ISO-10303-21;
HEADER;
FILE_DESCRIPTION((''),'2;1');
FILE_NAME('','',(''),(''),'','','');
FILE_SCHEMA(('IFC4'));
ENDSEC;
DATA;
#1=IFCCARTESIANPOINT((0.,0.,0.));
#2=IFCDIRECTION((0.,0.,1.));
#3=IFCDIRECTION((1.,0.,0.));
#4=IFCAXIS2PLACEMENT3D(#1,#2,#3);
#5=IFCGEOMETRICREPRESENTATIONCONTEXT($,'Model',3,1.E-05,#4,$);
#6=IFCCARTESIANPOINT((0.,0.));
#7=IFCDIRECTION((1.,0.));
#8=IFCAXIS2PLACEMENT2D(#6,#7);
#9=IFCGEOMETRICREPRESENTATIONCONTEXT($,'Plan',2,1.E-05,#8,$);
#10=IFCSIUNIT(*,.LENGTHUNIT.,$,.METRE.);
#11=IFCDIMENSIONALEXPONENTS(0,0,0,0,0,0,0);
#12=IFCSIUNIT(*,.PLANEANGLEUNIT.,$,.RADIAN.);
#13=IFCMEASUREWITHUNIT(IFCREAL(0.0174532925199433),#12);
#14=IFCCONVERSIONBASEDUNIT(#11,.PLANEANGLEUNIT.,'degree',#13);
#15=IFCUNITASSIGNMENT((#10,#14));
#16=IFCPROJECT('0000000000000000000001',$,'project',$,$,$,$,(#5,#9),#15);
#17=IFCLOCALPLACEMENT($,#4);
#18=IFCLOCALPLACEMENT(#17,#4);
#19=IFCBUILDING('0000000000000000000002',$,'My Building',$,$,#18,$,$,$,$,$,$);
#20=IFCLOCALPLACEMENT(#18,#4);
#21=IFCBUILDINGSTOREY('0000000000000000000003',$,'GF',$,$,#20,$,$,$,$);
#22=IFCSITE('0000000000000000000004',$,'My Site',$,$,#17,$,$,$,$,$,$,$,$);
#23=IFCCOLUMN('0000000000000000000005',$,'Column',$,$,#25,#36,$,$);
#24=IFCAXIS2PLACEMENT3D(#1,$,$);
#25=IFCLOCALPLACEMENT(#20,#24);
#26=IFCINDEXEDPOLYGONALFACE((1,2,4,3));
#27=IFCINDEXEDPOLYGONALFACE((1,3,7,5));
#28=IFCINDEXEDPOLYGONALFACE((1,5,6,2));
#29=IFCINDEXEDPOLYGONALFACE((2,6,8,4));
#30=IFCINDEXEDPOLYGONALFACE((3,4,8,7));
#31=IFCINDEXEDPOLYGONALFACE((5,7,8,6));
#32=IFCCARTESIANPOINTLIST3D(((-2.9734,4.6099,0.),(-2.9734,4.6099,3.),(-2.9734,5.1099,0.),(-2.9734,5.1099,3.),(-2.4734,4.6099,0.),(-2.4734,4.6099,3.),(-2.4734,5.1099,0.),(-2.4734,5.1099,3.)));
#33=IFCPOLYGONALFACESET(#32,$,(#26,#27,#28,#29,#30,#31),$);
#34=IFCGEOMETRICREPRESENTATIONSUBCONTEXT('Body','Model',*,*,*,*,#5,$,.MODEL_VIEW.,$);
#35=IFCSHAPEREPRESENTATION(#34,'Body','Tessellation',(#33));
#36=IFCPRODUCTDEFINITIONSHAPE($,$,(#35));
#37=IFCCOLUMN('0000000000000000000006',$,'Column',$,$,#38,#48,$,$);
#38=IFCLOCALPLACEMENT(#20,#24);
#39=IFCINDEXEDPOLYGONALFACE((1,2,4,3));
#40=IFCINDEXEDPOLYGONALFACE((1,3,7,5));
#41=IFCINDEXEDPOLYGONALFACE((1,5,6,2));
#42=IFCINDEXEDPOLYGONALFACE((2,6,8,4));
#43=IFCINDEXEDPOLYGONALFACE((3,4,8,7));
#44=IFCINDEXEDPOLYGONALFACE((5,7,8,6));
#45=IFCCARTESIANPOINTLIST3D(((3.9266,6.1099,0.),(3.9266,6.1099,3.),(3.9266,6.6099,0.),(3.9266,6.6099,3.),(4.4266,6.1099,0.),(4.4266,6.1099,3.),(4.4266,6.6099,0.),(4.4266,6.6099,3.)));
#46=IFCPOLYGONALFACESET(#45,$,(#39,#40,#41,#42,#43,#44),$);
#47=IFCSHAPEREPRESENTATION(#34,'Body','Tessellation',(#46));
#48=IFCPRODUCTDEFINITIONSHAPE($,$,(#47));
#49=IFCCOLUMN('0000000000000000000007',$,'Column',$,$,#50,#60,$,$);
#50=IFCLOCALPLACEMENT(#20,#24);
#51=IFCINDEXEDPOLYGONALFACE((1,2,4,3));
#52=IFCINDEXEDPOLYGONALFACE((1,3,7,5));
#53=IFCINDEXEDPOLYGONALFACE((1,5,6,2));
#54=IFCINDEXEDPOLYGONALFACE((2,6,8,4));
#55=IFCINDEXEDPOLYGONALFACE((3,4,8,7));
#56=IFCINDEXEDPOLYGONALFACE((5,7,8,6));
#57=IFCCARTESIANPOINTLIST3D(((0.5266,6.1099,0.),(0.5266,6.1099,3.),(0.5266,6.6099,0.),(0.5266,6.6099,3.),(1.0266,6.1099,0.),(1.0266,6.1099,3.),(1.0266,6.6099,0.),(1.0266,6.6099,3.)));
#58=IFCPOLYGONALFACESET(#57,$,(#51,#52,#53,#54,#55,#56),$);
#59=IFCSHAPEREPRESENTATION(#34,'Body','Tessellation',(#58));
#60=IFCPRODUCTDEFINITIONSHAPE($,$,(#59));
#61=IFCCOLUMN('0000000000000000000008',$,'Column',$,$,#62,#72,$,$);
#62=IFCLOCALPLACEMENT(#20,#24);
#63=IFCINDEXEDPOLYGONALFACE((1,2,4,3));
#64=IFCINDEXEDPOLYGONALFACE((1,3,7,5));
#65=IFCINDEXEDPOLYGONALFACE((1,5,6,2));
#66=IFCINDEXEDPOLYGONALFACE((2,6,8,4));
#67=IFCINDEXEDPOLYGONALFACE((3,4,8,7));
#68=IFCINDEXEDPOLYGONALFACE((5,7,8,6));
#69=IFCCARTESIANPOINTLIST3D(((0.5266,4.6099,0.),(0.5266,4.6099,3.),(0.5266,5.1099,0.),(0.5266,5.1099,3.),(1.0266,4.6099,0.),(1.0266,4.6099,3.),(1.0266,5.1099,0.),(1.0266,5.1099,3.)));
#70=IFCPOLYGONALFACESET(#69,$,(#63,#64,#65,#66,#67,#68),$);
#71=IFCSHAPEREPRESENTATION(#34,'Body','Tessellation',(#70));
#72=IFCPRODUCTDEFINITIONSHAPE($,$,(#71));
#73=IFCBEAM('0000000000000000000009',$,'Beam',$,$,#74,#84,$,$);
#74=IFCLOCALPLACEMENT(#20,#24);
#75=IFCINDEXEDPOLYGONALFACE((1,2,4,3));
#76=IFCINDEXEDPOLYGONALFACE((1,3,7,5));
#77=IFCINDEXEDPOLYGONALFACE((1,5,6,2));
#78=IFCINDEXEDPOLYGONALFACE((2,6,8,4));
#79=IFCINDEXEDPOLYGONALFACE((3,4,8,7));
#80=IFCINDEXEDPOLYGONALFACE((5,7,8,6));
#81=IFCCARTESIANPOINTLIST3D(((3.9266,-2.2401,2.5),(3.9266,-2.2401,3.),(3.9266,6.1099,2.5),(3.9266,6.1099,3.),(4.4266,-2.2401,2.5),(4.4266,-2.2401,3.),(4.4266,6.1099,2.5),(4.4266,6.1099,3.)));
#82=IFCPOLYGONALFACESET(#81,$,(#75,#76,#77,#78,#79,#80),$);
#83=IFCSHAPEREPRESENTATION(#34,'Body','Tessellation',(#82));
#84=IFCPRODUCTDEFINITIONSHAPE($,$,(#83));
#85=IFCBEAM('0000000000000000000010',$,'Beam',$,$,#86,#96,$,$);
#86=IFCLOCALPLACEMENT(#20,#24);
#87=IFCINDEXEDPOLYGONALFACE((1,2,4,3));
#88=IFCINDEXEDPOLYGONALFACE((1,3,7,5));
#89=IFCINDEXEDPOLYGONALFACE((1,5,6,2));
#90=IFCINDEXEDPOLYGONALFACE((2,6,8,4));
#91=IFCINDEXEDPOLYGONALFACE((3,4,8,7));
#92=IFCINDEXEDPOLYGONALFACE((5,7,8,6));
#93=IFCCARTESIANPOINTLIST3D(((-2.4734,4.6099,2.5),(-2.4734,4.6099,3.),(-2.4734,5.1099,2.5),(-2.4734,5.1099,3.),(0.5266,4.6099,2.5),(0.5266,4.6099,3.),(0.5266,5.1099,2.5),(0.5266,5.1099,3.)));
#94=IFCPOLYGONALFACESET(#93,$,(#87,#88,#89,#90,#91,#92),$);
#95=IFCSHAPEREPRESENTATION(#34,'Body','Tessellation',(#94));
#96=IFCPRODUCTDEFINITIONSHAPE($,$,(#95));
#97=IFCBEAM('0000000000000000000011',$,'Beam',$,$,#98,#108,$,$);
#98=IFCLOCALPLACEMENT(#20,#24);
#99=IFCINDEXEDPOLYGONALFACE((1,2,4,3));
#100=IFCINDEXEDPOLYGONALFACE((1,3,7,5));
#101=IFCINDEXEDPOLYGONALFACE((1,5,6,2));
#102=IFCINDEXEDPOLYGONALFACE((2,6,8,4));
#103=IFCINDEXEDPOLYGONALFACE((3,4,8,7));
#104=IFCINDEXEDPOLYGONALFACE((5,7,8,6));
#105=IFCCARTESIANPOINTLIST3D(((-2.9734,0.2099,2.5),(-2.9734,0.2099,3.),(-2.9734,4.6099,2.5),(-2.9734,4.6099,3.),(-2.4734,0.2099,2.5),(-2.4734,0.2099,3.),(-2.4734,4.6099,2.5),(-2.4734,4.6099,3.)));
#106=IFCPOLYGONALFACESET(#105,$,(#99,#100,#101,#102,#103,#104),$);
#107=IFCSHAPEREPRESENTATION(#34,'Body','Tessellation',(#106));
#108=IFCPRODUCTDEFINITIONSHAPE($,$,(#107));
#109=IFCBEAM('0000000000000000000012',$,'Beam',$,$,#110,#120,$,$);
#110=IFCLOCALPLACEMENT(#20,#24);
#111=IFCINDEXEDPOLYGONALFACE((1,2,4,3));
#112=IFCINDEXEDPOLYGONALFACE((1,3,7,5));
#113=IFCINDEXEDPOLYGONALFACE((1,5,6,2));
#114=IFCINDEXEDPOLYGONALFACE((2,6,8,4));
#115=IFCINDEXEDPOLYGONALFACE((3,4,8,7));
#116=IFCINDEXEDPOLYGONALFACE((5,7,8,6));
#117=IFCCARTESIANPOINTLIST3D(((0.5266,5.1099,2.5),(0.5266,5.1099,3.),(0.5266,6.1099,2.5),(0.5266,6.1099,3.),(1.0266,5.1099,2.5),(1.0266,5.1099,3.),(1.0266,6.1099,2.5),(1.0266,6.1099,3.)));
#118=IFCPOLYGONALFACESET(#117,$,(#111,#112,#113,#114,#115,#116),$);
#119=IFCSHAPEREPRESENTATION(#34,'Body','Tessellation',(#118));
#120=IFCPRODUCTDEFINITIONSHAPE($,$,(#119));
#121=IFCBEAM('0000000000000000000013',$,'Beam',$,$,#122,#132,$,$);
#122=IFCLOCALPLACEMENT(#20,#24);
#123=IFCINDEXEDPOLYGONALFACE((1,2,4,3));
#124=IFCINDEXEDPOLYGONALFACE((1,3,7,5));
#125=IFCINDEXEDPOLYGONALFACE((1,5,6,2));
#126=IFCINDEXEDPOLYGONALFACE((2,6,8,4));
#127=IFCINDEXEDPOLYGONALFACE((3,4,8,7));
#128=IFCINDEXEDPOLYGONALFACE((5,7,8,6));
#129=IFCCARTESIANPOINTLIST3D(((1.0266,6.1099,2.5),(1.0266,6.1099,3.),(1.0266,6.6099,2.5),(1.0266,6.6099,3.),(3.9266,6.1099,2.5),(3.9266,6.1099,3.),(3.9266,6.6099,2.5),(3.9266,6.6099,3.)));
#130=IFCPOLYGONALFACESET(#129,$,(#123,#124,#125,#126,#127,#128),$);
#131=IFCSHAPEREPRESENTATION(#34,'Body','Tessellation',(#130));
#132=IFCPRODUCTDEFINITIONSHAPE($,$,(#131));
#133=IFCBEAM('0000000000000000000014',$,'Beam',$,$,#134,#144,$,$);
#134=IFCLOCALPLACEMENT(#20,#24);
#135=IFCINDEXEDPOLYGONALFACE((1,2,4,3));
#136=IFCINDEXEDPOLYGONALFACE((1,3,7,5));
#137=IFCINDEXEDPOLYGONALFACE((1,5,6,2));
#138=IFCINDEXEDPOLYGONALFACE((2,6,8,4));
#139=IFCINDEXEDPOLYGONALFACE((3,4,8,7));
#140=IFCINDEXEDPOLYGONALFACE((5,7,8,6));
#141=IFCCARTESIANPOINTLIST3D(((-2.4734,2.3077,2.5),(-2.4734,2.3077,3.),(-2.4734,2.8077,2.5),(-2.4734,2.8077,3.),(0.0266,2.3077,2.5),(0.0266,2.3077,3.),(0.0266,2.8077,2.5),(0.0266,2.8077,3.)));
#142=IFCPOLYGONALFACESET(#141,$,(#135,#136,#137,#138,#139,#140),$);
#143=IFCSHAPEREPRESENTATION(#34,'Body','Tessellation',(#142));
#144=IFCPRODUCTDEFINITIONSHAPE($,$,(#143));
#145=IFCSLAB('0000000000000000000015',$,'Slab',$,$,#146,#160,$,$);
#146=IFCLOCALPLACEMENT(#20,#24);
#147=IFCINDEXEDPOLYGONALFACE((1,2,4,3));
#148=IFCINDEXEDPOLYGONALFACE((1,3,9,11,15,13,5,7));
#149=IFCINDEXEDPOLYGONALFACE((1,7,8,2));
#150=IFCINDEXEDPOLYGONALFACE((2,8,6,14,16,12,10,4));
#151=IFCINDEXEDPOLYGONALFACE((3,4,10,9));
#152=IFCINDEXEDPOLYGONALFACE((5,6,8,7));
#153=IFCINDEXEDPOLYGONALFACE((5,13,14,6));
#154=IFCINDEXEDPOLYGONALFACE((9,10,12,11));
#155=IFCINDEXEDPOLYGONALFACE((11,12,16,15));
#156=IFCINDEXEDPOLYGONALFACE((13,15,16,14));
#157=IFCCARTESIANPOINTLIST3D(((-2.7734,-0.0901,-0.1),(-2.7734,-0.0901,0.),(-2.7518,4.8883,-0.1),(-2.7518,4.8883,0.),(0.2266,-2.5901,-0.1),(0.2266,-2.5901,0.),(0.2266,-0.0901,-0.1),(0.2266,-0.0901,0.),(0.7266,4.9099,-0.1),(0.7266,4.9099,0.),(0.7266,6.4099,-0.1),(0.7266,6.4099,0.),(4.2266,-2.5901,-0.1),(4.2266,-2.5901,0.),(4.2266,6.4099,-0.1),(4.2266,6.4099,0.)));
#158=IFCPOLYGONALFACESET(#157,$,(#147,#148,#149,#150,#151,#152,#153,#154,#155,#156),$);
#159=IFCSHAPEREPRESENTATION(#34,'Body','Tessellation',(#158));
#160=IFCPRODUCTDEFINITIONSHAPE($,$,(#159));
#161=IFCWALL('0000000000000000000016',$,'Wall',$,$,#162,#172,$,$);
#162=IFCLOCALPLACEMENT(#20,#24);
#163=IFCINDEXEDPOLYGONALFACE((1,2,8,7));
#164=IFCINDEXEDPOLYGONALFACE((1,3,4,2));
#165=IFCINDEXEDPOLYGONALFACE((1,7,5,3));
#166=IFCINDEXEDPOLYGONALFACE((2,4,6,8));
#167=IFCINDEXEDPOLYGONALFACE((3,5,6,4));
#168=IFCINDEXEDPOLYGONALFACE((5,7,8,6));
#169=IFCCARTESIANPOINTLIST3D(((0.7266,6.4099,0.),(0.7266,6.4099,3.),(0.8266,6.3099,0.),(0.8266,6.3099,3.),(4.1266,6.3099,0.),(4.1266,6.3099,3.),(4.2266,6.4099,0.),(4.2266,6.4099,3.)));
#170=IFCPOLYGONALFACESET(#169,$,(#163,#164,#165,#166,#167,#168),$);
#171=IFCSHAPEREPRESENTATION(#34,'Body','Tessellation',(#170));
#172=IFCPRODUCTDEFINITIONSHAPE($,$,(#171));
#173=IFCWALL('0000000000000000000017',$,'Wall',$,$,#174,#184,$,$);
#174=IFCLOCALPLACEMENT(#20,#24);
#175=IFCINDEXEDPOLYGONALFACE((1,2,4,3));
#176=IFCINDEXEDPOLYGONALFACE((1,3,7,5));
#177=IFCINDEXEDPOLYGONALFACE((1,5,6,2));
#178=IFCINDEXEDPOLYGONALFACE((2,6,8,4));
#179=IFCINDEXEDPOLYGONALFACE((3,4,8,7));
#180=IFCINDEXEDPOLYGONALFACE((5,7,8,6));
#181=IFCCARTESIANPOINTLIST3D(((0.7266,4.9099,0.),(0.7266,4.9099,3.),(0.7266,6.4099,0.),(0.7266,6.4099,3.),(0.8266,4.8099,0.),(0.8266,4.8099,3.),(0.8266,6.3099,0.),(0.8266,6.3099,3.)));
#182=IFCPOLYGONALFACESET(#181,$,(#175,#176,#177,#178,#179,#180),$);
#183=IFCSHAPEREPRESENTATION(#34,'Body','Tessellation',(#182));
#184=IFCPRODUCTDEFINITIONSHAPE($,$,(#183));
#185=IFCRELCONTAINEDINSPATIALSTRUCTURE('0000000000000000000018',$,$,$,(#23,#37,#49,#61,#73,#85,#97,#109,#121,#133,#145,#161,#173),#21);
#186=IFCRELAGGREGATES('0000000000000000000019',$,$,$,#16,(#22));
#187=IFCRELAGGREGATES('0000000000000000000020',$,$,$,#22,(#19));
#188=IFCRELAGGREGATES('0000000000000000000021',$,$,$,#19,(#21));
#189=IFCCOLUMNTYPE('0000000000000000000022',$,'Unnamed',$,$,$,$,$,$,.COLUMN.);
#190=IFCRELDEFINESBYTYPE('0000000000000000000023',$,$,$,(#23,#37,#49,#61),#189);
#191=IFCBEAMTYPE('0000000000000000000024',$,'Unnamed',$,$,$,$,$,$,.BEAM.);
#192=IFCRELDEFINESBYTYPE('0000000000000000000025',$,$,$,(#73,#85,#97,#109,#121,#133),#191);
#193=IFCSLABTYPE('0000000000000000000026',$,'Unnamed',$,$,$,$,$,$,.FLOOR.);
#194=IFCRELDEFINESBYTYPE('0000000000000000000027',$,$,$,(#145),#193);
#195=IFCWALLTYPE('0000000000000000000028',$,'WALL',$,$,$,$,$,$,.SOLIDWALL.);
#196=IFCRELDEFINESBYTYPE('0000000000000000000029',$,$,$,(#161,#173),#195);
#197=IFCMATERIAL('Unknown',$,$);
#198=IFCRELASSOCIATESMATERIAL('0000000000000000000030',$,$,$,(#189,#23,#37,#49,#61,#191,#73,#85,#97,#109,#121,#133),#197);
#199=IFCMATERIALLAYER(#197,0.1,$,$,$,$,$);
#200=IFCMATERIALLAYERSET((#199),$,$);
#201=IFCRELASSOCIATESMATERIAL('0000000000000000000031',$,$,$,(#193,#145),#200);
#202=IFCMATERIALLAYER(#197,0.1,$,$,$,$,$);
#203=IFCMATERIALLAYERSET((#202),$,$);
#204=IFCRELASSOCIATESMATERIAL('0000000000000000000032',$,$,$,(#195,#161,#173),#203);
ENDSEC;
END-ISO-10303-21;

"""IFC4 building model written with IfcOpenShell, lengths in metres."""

from ifc_helpers import new_model, entity, si_unit, converted_unit, frame, origin_with_axes, origin_2d_with_axis, place, context, subcontext, project, spatial, line, indexed_curve, rectangle, outline, extrude, material, layer, layer_set, layer_usage, material_profile, profile_set, profile_usage, type_object, element, save


model = new_model("IFC4")

# Units and contexts
model_context = context("Model", 3, precision=1e-05, world=origin_with_axes())
plan_context = context("Plan", 2, precision=1e-05, world=origin_2d_with_axis())
body_context_1 = subcontext(model_context, "Body", "Model", "MODEL_VIEW")
ifc_project = project(units=[si_unit("LENGTHUNIT", "METRE"), converted_unit("PLANEANGLEUNIT", "degree", entity("IfcReal", 0.0174532925199433), si_unit("PLANEANGLEUNIT", "RADIAN"), dimensions=[0, 0, 0, 0, 0, 0, 0])], contexts=[model_context, plan_context])

# Site, building, storey
site_placement = place(None, origin_with_axes())
site = spatial("IfcSite", under=ifc_project, at=site_placement, Name="My Site")
building_placement = place(site_placement, origin_with_axes())
building = spatial("IfcBuilding", under=site, at=building_placement, Name="My Building")
storey_placement = place(building_placement, origin_with_axes())
storey = spatial("IfcBuildingStorey", under=building, at=storey_placement, Name="GF")

# Columns
ifc_material = material(Name="Unknown")
ifc_material_profile_1 = material_profile(ifc_material, rectangle(XDim=0.5, YDim=0.5))
ifc_profile_set_1 = profile_set([ifc_material_profile_1])
ifc_profile_usage_1 = profile_usage(ifc_profile_set_1, cardinal=5)
column_type = type_object("IfcColumnType", Name="Unnamed", PredefinedType="COLUMN", material=ifc_profile_set_1)
column_1_placement = place(storey_placement, frame((-2.7234, 4.8599, 0.0), z_axis=(0.0, 0.0, 1.0), x_axis=(1.0, 0.0, 0.0)))
element("IfcColumn", 1, at=column_1_placement, inside=storey, type_object=column_type, material=ifc_profile_usage_1, Name="Column", context=body_context_1, shape_type="SweptSolid", body=[
    extrude(rectangle(XDim=0.5, YDim=0.5), origin_with_axes(), (0.0, 0.0, 1.0), 3.0),
])
ifc_profile_usage_2 = profile_usage(ifc_profile_set_1, cardinal=5)
column_2_placement = place(storey_placement, frame((4.1766, 6.3599, 0.0), z_axis=(0.0, 0.0, 1.0), x_axis=(1.0, 0.0, 0.0)))
element("IfcColumn", 2, at=column_2_placement, inside=storey, type_object=column_type, material=ifc_profile_usage_2, Name="Column", context=body_context_1, shape_type="SweptSolid", body=[
    extrude(rectangle(XDim=0.5, YDim=0.5), origin_with_axes(), (0.0, 0.0, 1.0), 3.0),
])
ifc_profile_usage_3 = profile_usage(ifc_profile_set_1, cardinal=5)
column_3_placement = place(storey_placement, frame((0.7766, 6.3599, 0.0), z_axis=(0.0, 0.0, 1.0), x_axis=(1.0, 0.0, 0.0)))
element("IfcColumn", 3, at=column_3_placement, inside=storey, type_object=column_type, material=ifc_profile_usage_3, Name="Column", context=body_context_1, shape_type="SweptSolid", body=[
    extrude(rectangle(XDim=0.5, YDim=0.5), origin_with_axes(), (0.0, 0.0, 1.0), 3.0),
])
ifc_profile_usage_4 = profile_usage(ifc_profile_set_1, cardinal=5)
column_4_placement = place(storey_placement, frame((0.7766, 4.8599, 0.0), z_axis=(0.0, 0.0, 1.0), x_axis=(1.0, 0.0, 0.0)))
element("IfcColumn", 4, at=column_4_placement, inside=storey, type_object=column_type, material=ifc_profile_usage_4, Name="Column", context=body_context_1, shape_type="SweptSolid", body=[
    extrude(rectangle(XDim=0.5, YDim=0.5), origin_with_axes(), (0.0, 0.0, 1.0), 3.0),
])

# Beams
ifc_material_profile_2 = material_profile(ifc_material, rectangle(XDim=0.5, YDim=0.5))
ifc_profile_set_2 = profile_set([ifc_material_profile_2])
ifc_profile_usage_5 = profile_usage(ifc_profile_set_2, cardinal=7)
beam_type = type_object("IfcBeamType", Name="Unnamed", PredefinedType="BEAM", material=ifc_profile_set_2)
beam_1_placement = place(storey_placement, frame((4.4266, 6.1099, 3.0), z_axis=(0.0, -1.0, 0.0), x_axis=(1.0, 0.0, 0.0)))
element("IfcBeam", 5, at=beam_1_placement, inside=storey, type_object=beam_type, material=ifc_profile_usage_5, Name="Beam", context=body_context_1, shape_type="SweptSolid", body=[
    extrude(rectangle(XDim=0.5, YDim=0.5), frame((-0.25, -0.25, 0.0), z_axis=(0.0, 0.0, 1.0), x_axis=(1.0, 0.0, 0.0)), (0.0, 0.0, 1.0), 8.35),
])
ifc_profile_usage_6 = profile_usage(ifc_profile_set_2, cardinal=7)
beam_2_placement = place(storey_placement, frame((-2.4734, 5.1099, 3.0), z_axis=(1.0, 0.0, 0.0), x_axis=(0.0, 1.0, 0.0)))
element("IfcBeam", 6, at=beam_2_placement, inside=storey, type_object=beam_type, material=ifc_profile_usage_6, Name="Beam", context=body_context_1, shape_type="SweptSolid", body=[
    extrude(rectangle(XDim=0.5, YDim=0.5), frame((-0.25, -0.25, 0.0), z_axis=(0.0, 0.0, 1.0), x_axis=(1.0, 0.0, 0.0)), (0.0, 0.0, 1.0), 3.0),
])
ifc_profile_usage_7 = profile_usage(ifc_profile_set_2, cardinal=7)
beam_3_placement = place(storey_placement, frame((-2.4734, 4.6099, 3.0), z_axis=(0.0, -1.0, 0.0), x_axis=(1.0, 0.0, 0.0)))
element("IfcBeam", 7, at=beam_3_placement, inside=storey, type_object=beam_type, material=ifc_profile_usage_7, Name="Beam", context=body_context_1, shape_type="SweptSolid", body=[
    extrude(rectangle(XDim=0.5, YDim=0.5), frame((-0.25, -0.25, 0.0), z_axis=(0.0, 0.0, 1.0), x_axis=(1.0, 0.0, 0.0)), (0.0, 0.0, 1.0), 4.4),
])
ifc_profile_usage_8 = profile_usage(ifc_profile_set_2, cardinal=7)
beam_4_placement = place(storey_placement, frame((1.0266, 6.1099, 3.0), z_axis=(0.0, -1.0, 0.0), x_axis=(1.0, 0.0, 0.0)))
element("IfcBeam", 8, at=beam_4_placement, inside=storey, type_object=beam_type, material=ifc_profile_usage_8, Name="Beam", context=body_context_1, shape_type="SweptSolid", body=[
    extrude(rectangle(XDim=0.5, YDim=0.5), frame((-0.25, -0.25, 0.0), z_axis=(0.0, 0.0, 1.0), x_axis=(1.0, 0.0, 0.0)), (0.0, 0.0, 1.0), 1.0),
])
ifc_profile_usage_9 = profile_usage(ifc_profile_set_2, cardinal=7)
beam_5_placement = place(storey_placement, frame((1.0266, 6.6099, 3.0), z_axis=(1.0, -0.000001, 0.0), x_axis=(0.000001, 1.0, 0.0)))
element("IfcBeam", 9, at=beam_5_placement, inside=storey, type_object=beam_type, material=ifc_profile_usage_9, Name="Beam", context=body_context_1, shape_type="SweptSolid", body=[
    extrude(rectangle(XDim=0.5, YDim=0.5), frame((-0.25, -0.25, 0.0), z_axis=(0.0, 0.0, 1.0), x_axis=(1.0, 0.0, 0.0)), (0.0, 0.0, 1.0), 2.9),
])
ifc_profile_usage_10 = profile_usage(ifc_profile_set_2, cardinal=7)
beam_6_placement = place(storey_placement, frame((-2.4734, 2.8077, 3.0), z_axis=(1.0, 0.0, 0.0), x_axis=(0.0, 1.0, 0.0)))
element("IfcBeam", 10, at=beam_6_placement, inside=storey, type_object=beam_type, material=ifc_profile_usage_10, Name="Beam", context=body_context_1, shape_type="SweptSolid", body=[
    extrude(rectangle(XDim=0.5, YDim=0.5), frame((-0.25, -0.25, 0.0), z_axis=(0.0, 0.0, 1.0), x_axis=(1.0, 0.0, 0.0)), (0.0, 0.0, 1.0), 2.5),
])

# Slab
ifc_layer_1 = layer(ifc_material, 0.1)
ifc_layer_set_1 = layer_set([ifc_layer_1])
ifc_layer_usage_1 = layer_usage(ifc_layer_set_1, "AXIS3", "POSITIVE", -0.1)
slab_type = type_object("IfcSlabType", Name="Unnamed", PredefinedType="FLOOR", material=ifc_layer_set_1)
slab_placement = place(storey_placement, frame((0.7266, 6.4099, 0.0), z_axis=(0.0, 0.0, 1.0), x_axis=(1.0, 0.0, 0.0)))
element("IfcSlab", 11, at=slab_placement, inside=storey, type_object=slab_type, material=ifc_layer_usage_1, Name="Slab", context=body_context_1, shape_type="SweptSolid", body=[
    extrude(outline(indexed_curve([(0.0, 0.0), (3.5, 0.0), (3.5, -9.0), (-0.5, -9.0), (-0.5, -6.5), (-3.5, -6.5), (-3.4784, -1.5216), (0.0, -1.5), (0.0, 0.0)])), frame((0.0, 0.0, -0.1), z_axis=(0.0, 0.0, 1.0), x_axis=(1.0, 0.0, 0.0)), (0.0, 0.0, 1.0), 0.1),
])

# Walls
ifc_layer_2 = layer(ifc_material, 0.1)
ifc_layer_set_2 = layer_set([ifc_layer_2])
ifc_layer_usage_2 = layer_usage(ifc_layer_set_2, "AXIS2", "POSITIVE", 0.0)
wall_type = type_object("IfcWallType", Name="WALL", PredefinedType="SOLIDWALL", material=ifc_layer_set_2)
wall_1_placement = place(storey_placement, frame((4.2266, 6.4099, 0.0), z_axis=(0.0, 0.0, 1.0), x_axis=(-1.0, 0.0, 0.0)))
element("IfcWall", 12, at=wall_1_placement, inside=storey, type_object=wall_type, material=ifc_layer_usage_2, Name="Wall", context=body_context_1, shape_type="SweptSolid", body=[
    extrude(outline(indexed_curve([(0.0, 0.0), (0.1, 0.1), (3.4, 0.1), (3.5, 0.0)], segments=[line(1, 2, 3, 4, 1)])), origin_with_axes(), (0.0, 0.0, 1.0), 3.0),
])
ifc_layer_usage_3 = layer_usage(ifc_layer_set_2, "AXIS2", "POSITIVE", 0.0)
wall_2_placement = place(storey_placement, frame((0.7266, 6.4099, 0.0), z_axis=(0.0, 0.0, 1.0), x_axis=(0.0, -1.0, 0.0)))
element("IfcWall", 13, at=wall_2_placement, inside=storey, type_object=wall_type, material=ifc_layer_usage_3, Name="Wall", context=body_context_1, shape_type="SweptSolid", body=[
    extrude(outline(indexed_curve([(0.0, 0.0), (0.1, 0.1), (1.6, 0.1), (1.5, 0.0)], segments=[line(1, 2, 3, 4, 1)])), origin_with_axes(), (0.0, 0.0, 1.0), 3.0),
])

save(model, "model.ifc")
